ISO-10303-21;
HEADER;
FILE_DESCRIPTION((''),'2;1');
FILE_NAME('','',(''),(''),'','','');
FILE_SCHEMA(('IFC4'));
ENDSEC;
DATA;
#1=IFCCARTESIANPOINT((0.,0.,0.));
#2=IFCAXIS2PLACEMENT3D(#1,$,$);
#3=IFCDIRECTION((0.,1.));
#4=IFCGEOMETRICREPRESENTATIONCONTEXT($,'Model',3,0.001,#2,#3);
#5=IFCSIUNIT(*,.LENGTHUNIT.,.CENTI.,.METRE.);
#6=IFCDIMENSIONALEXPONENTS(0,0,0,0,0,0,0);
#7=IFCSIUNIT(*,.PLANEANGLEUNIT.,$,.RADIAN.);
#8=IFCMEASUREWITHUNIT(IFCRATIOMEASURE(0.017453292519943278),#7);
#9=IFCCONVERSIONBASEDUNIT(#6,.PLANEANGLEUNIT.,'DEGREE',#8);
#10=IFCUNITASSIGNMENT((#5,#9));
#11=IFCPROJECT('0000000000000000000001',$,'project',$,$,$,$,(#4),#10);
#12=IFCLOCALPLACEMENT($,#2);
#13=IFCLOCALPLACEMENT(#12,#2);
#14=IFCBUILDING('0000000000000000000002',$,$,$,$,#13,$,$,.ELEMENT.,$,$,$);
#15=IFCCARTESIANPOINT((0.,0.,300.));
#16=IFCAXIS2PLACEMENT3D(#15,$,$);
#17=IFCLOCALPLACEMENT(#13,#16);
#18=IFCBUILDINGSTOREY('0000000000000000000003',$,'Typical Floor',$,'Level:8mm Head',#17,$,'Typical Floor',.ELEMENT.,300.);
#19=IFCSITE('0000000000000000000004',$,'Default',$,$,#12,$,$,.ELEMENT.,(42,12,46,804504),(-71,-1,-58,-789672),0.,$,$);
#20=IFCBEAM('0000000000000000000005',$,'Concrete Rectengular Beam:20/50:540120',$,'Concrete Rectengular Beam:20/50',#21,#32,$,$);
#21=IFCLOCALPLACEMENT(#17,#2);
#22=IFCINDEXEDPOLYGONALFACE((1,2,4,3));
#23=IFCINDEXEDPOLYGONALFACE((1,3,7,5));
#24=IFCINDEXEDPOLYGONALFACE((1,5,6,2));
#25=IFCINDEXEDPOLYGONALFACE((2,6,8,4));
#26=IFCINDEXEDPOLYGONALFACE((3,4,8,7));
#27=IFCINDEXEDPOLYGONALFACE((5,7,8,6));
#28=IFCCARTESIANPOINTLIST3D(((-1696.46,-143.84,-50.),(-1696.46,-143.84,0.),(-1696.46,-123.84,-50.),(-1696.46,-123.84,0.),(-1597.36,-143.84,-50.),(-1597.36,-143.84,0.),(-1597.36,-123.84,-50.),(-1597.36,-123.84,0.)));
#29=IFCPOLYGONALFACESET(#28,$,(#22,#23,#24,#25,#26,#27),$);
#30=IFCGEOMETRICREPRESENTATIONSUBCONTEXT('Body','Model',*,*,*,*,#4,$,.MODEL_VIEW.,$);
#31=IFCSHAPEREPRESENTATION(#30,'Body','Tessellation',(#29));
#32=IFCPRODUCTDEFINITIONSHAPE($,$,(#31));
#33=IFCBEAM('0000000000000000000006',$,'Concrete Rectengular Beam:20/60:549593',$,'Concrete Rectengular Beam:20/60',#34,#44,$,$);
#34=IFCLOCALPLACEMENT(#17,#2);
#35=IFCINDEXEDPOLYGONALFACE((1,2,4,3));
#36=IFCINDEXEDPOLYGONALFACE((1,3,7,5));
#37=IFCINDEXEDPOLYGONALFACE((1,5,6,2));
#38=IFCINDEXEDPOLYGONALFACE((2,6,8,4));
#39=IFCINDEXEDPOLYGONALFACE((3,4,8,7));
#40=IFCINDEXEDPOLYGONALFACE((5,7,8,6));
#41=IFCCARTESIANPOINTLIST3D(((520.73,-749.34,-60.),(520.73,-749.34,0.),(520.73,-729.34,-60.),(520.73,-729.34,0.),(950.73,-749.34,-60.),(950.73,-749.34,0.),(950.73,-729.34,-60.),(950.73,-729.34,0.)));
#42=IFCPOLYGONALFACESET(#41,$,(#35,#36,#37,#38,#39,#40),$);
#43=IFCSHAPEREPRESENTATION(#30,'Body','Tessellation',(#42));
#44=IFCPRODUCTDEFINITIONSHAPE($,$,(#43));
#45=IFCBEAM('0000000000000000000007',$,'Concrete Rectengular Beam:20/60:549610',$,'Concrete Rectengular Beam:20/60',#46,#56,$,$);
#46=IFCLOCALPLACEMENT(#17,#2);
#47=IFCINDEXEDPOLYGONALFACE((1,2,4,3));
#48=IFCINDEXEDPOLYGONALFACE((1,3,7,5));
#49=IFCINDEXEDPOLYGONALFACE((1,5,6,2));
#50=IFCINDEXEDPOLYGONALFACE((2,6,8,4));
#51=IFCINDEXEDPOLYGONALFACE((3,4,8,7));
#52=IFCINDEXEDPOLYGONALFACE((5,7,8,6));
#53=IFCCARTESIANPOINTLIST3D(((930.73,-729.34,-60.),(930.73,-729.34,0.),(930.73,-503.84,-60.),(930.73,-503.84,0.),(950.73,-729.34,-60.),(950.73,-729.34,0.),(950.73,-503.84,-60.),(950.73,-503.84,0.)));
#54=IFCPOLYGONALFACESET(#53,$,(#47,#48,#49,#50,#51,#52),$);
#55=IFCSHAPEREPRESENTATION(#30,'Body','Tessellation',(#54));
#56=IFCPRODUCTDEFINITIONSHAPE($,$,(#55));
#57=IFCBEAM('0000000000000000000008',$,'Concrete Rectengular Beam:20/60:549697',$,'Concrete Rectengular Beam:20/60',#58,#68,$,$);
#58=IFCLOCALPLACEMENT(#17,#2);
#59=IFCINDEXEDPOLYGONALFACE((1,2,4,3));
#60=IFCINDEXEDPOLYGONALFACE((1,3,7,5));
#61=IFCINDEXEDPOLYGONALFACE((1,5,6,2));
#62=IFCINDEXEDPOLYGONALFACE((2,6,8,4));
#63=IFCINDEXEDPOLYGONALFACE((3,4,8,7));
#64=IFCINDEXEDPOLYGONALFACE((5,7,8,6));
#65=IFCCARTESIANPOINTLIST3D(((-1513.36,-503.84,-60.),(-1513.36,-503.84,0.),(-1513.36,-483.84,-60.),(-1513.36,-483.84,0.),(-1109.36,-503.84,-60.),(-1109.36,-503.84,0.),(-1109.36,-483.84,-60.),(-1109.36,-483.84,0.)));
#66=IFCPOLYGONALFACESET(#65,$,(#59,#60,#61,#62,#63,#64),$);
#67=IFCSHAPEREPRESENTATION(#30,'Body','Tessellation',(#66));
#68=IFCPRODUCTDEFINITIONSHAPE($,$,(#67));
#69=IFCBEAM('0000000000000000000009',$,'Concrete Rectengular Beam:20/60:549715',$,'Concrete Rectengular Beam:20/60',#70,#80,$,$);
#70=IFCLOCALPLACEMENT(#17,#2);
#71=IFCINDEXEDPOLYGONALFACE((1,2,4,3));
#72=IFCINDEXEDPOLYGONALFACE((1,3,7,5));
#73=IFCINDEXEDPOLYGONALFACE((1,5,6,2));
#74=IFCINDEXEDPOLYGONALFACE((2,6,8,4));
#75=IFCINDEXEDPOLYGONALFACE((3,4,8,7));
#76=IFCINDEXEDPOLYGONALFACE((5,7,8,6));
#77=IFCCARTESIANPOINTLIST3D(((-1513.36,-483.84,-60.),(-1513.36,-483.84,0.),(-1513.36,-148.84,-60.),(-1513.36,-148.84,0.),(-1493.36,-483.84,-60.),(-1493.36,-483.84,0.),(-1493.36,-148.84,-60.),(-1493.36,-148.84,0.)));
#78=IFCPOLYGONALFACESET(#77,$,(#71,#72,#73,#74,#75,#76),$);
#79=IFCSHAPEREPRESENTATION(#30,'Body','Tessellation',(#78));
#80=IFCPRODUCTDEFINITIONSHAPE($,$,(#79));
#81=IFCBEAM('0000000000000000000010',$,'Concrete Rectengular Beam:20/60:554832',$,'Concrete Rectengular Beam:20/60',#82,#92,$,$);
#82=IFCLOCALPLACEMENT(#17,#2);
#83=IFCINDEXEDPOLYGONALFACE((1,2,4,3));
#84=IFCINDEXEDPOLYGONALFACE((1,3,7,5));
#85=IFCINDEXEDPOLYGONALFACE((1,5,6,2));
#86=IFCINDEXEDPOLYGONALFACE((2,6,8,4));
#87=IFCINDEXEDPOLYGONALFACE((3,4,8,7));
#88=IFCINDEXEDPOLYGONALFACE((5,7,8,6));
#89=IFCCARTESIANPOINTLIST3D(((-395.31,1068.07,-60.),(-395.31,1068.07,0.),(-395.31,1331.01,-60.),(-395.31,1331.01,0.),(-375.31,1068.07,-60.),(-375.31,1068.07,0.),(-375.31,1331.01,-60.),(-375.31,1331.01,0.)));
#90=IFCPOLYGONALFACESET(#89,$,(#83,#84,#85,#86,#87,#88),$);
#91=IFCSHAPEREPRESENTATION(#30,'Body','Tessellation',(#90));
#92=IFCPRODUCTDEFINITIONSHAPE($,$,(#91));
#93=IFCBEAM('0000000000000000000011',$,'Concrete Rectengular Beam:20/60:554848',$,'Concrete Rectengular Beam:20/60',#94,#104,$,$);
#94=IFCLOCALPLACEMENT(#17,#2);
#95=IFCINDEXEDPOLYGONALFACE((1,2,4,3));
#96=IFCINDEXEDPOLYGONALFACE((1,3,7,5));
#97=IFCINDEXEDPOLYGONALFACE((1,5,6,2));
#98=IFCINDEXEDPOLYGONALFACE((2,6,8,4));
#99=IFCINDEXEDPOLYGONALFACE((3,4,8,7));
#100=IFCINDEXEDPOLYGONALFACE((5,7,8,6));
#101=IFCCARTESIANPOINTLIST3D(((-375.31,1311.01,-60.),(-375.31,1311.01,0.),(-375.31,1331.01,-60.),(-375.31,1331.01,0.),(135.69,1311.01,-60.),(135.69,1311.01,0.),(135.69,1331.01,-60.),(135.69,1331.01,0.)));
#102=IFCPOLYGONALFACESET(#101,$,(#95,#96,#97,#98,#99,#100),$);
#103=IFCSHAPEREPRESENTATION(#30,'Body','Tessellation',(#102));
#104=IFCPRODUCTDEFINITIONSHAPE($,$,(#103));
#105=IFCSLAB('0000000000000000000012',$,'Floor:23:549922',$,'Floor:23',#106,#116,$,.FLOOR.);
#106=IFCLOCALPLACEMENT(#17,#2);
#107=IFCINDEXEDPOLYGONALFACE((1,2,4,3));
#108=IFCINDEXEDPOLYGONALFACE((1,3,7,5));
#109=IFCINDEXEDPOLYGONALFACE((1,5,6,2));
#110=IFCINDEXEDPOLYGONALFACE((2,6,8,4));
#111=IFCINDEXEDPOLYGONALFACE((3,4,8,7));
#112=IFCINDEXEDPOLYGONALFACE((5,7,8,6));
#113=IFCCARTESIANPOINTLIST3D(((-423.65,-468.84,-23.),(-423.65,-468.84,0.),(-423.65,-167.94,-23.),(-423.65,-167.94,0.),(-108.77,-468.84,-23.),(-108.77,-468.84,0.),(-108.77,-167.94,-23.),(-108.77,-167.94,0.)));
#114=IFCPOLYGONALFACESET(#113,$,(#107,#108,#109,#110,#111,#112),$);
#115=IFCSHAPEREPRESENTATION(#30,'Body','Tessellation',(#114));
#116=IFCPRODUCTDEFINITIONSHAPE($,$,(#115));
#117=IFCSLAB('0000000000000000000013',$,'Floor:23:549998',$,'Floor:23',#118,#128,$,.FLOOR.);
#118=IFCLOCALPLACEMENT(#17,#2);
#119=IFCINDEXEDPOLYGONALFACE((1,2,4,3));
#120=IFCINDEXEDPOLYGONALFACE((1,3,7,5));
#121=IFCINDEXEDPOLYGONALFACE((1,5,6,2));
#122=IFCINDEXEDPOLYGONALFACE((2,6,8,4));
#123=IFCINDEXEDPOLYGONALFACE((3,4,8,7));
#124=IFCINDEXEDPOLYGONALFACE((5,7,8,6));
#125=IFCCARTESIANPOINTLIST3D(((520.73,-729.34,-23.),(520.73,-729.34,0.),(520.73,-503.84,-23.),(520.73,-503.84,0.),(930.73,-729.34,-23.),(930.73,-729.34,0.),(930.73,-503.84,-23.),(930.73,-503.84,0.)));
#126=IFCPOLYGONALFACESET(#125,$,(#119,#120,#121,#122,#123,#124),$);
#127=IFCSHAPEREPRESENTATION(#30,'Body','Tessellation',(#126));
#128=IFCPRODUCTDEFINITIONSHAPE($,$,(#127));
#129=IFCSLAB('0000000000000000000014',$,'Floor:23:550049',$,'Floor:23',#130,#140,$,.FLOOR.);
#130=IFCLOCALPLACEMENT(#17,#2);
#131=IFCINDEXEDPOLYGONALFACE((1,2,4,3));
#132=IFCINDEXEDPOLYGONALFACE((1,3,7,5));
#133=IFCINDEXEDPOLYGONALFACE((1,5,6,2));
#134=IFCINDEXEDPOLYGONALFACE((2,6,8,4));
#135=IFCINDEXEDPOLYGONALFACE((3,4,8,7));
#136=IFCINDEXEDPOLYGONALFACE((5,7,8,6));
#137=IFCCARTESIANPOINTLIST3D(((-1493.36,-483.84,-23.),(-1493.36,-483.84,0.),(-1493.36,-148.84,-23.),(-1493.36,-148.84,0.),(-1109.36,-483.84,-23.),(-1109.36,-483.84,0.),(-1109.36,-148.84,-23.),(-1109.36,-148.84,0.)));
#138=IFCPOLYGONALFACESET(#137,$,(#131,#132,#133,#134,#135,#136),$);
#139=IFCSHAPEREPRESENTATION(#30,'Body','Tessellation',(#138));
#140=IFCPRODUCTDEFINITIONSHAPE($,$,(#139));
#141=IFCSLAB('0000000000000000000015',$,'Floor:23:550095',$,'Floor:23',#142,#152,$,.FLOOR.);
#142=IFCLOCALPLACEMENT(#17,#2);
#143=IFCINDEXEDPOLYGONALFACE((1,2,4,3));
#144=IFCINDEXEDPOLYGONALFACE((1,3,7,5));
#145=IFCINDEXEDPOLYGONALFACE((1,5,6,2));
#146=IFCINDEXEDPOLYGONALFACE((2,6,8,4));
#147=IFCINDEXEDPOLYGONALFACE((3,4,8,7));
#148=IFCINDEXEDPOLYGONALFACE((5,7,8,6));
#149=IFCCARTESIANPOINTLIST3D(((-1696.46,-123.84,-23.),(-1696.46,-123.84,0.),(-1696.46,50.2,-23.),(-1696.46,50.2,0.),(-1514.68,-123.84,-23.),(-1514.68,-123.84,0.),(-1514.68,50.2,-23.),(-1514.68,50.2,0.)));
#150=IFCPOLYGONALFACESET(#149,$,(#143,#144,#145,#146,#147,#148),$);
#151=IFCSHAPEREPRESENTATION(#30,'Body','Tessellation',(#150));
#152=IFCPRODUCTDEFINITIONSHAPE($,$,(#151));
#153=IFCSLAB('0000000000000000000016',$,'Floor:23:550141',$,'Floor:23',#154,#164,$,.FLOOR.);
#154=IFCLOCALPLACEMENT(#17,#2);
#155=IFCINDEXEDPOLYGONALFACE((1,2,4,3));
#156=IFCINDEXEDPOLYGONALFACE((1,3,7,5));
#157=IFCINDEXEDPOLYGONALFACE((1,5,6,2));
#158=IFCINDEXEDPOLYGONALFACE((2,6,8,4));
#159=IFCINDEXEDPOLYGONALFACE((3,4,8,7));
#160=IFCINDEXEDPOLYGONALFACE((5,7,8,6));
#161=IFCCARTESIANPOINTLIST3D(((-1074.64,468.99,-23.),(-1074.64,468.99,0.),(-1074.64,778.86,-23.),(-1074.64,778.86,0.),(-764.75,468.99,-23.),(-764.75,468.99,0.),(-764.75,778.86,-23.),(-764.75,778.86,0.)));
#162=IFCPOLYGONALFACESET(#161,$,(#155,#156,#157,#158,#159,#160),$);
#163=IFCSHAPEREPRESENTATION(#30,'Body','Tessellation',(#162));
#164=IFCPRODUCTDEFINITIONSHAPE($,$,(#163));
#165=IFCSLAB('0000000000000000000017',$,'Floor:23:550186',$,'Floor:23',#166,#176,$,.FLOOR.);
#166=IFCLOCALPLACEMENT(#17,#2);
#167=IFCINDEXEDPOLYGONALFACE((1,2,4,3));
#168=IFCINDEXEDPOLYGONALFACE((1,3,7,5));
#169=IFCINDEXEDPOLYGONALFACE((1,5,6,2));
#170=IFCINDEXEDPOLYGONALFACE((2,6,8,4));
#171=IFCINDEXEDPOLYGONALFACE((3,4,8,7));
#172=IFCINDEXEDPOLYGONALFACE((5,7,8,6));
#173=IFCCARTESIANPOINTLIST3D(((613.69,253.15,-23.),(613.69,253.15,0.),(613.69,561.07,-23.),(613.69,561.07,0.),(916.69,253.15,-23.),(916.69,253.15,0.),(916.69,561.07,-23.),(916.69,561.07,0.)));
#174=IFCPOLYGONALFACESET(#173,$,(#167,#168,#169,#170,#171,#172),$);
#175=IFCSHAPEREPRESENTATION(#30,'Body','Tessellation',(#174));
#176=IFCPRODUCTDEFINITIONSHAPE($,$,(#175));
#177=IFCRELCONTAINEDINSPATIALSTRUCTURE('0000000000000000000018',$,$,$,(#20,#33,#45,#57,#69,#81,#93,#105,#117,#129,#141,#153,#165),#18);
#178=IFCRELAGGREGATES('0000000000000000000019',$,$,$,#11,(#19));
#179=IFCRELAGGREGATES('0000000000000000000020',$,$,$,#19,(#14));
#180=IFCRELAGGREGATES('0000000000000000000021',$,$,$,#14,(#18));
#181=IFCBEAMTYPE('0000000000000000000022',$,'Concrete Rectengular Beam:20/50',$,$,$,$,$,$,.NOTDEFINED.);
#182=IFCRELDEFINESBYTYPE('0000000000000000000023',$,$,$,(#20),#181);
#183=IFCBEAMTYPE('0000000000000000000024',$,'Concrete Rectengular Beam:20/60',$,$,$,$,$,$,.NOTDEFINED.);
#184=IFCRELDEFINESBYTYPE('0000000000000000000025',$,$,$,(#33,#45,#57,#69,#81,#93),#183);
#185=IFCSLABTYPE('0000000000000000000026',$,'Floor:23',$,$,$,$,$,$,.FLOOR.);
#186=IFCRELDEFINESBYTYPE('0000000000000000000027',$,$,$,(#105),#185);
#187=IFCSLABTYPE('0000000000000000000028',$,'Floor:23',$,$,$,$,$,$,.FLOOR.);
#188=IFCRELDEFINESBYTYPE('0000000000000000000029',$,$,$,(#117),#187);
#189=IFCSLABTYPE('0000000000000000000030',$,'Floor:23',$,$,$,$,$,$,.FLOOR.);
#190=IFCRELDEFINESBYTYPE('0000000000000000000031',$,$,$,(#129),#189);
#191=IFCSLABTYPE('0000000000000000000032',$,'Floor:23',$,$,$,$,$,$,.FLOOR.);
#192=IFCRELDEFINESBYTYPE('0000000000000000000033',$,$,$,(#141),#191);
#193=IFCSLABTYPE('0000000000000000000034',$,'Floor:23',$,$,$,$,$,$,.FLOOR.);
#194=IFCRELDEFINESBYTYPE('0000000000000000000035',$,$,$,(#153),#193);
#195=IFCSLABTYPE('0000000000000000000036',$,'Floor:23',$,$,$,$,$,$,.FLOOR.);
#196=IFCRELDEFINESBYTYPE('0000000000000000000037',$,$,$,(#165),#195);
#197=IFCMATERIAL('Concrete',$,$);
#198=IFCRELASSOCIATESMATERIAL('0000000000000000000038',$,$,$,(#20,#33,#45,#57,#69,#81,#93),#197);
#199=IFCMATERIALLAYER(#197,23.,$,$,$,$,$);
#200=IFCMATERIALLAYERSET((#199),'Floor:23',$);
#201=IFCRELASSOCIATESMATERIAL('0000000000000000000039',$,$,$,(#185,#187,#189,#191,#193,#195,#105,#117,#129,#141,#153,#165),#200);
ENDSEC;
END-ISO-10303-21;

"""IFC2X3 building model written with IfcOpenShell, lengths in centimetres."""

from ifc_helpers import new_model, entity, si_unit, converted_unit, direction, frame, frame_2d, origin, origin_2d_with_axis, place, context, subcontext, project, spatial, rectangle, extrude, material, layer, layer_set, layer_usage, type_object, element, save


model = new_model("IFC2X3")

# Units and contexts
model_context = context("Model", 3, precision=0.001, world=origin(), true_north=direction((0.0, 1.0)))
body_context = subcontext(model_context, "Body", "Model", "MODEL_VIEW")
ifc_project = project(units=[si_unit("LENGTHUNIT", "METRE", prefix="CENTI"), converted_unit("PLANEANGLEUNIT", "DEGREE", entity("IfcRatioMeasure", 0.017453292519943278), si_unit("PLANEANGLEUNIT", "RADIAN"), dimensions=[0, 0, 0, 0, 0, 0, 0])], contexts=[model_context])

# Site, building, storey
site_placement = place(None, origin())
site = spatial("IfcSite", under=ifc_project, at=site_placement, Name="Default", CompositionType="ELEMENT", RefLatitude=(42, 12, 46, 804504), RefLongitude=(-71, -1, -58, -789672), RefElevation=0.0)
building_placement = place(site_placement, origin())
building = spatial("IfcBuilding", under=site, at=building_placement, CompositionType="ELEMENT")
storey_placement = place(building_placement, frame((0.0, 0.0, 300.0)))
storey = spatial("IfcBuildingStorey", under=building, at=storey_placement, Name="Typical Floor", ObjectType="Level:8mm Head", LongName="Typical Floor", CompositionType="ELEMENT", Elevation=300.0)

# Beams
ifc_material = material(Name="Concrete")
beam_type_1 = type_object("IfcBeamType", Name="Concrete Rectengular Beam:20/50", PredefinedType="NOTDEFINED")
beam_1_placement = place(storey_placement, frame((-1706.46, -133.84, 0.0)))
element("IfcBeam", 1, at=beam_1_placement, inside=storey, type_object=beam_type_1, material=ifc_material, Name="Concrete Rectengular Beam:20/50:540120", ObjectType="Concrete Rectengular Beam:20/50", context=body_context, shape_type="SweptSolid", body=[
    extrude(rectangle(XDim=50.0, YDim=20.0, at=frame_2d((0.0, 0.0), x_axis=(1.0, 0.0))), frame((10.0, 0.0, -25.0), z_axis=(1.0, 0.0, 0.0), x_axis=(0.0, 0.0, -1.0)), (0.0, 0.0, 1.0), 99.11),
])
beam_type_2 = type_object("IfcBeamType", Name="Concrete Rectengular Beam:20/60", PredefinedType="NOTDEFINED")
beam_2_placement = place(storey_placement, frame((510.73, -739.34, 0.0)))
element("IfcBeam", 2, at=beam_2_placement, inside=storey, type_object=beam_type_2, material=ifc_material, Name="Concrete Rectengular Beam:20/60:549593", ObjectType="Concrete Rectengular Beam:20/60", context=body_context, shape_type="SweptSolid", body=[
    extrude(rectangle(XDim=60.0, YDim=20.0, at=frame_2d((0.0, 0.0), x_axis=(1.0, 0.0))), frame((10.0, 0.0, -30.0), z_axis=(1.0, 0.0, 0.0), x_axis=(0.0, 0.0, -1.0)), (0.0, 0.0, 1.0), 430.0),
])
beam_3_placement = place(storey_placement, frame((940.73, -739.34, 0.0), z_axis=(0.0, 0.0, 1.0), x_axis=(0.0, 1.0, 0.0)))
element("IfcBeam", 3, at=beam_3_placement, inside=storey, type_object=beam_type_2, material=ifc_material, Name="Concrete Rectengular Beam:20/60:549610", ObjectType="Concrete Rectengular Beam:20/60", context=body_context, shape_type="SweptSolid", body=[
    extrude(rectangle(XDim=60.0, YDim=20.0, at=frame_2d((0.0, 0.0), x_axis=(1.0, 0.0))), frame((10.0, 0.0, -30.0), z_axis=(1.0, 0.0, 0.0), x_axis=(0.0, 0.0, -1.0)), (0.0, 0.0, 1.0), 225.5),
])
beam_4_placement = place(storey_placement, frame((-1099.36, -493.84, 0.0), z_axis=(0.0, 0.0, 1.0), x_axis=(-1.0, 0.0, 0.0)))
element("IfcBeam", 4, at=beam_4_placement, inside=storey, type_object=beam_type_2, material=ifc_material, Name="Concrete Rectengular Beam:20/60:549697", ObjectType="Concrete Rectengular Beam:20/60", context=body_context, shape_type="SweptSolid", body=[
    extrude(rectangle(XDim=60.0, YDim=20.0, at=frame_2d((0.0, 0.0), x_axis=(1.0, 0.0))), frame((10.0, 0.0, -30.0), z_axis=(1.0, 0.0, 0.0), x_axis=(0.0, 0.0, -1.0)), (0.0, 0.0, 1.0), 404.0),
])
beam_5_placement = place(storey_placement, frame((-1503.36, -493.84, 0.0), z_axis=(0.0, 0.0, 1.0), x_axis=(0.0, 1.0, 0.0)))
element("IfcBeam", 5, at=beam_5_placement, inside=storey, type_object=beam_type_2, material=ifc_material, Name="Concrete Rectengular Beam:20/60:549715", ObjectType="Concrete Rectengular Beam:20/60", context=body_context, shape_type="SweptSolid", body=[
    extrude(rectangle(XDim=60.0, YDim=20.0, at=frame_2d((0.0, 0.0), x_axis=(1.0, 0.0))), frame((10.0, 0.0, -30.0), z_axis=(1.0, 0.0, 0.0), x_axis=(0.0, 0.0, -1.0)), (0.0, 0.0, 1.0), 335.0),
])
beam_6_placement = place(storey_placement, frame((-385.31, 1058.07, 0.0), z_axis=(0.0, 0.0, 1.0), x_axis=(0.0, 1.0, 0.0)))
element("IfcBeam", 6, at=beam_6_placement, inside=storey, type_object=beam_type_2, material=ifc_material, Name="Concrete Rectengular Beam:20/60:554832", ObjectType="Concrete Rectengular Beam:20/60", context=body_context, shape_type="SweptSolid", body=[
    extrude(rectangle(XDim=60.0, YDim=20.0, at=origin_2d_with_axis()), frame((10.0, 0.0, -30.0), z_axis=(1.0, 0.0, 0.0), x_axis=(0.0, 0.0, -1.0)), (0.0, 0.0, 1.0), 262.94),
])
beam_7_placement = place(storey_placement, frame((-385.31, 1321.01, 0.0)))
element("IfcBeam", 7, at=beam_7_placement, inside=storey, type_object=beam_type_2, material=ifc_material, Name="Concrete Rectengular Beam:20/60:554848", ObjectType="Concrete Rectengular Beam:20/60", context=body_context, shape_type="SweptSolid", body=[
    extrude(rectangle(XDim=60.0, YDim=20.0, at=frame_2d((0.0, 0.0), x_axis=(1.0, 0.0))), frame((10.0, 0.0, -30.0), z_axis=(1.0, 0.0, 0.0), x_axis=(0.0, 0.0, -1.0)), (0.0, 0.0, 1.0), 511.0),
])

# Slabs
ifc_layer = layer(ifc_material, 23.0)
ifc_layer_set = layer_set([ifc_layer], Name="Floor:23")
ifc_layer_usage_1 = layer_usage(ifc_layer_set, "AXIS3", "POSITIVE", 0.0)
slab_type_1 = type_object("IfcSlabType", Name="Floor:23", PredefinedType="FLOOR", material=ifc_layer_set)
slab_1_placement = place(storey_placement, origin())
element("IfcSlab", 8, at=slab_1_placement, inside=storey, type_object=slab_type_1, material=ifc_layer_usage_1, Name="Floor:23:549922", ObjectType="Floor:23", PredefinedType="FLOOR", context=body_context, shape_type="SweptSolid", body=[
    extrude(rectangle(XDim=300.91, YDim=314.88, at=frame_2d((0.0, 0.0), x_axis=(1.0, 0.0))), frame((-266.21, -318.39, 0.0), z_axis=(0.0, 0.0, -1.0), x_axis=(0.0, 1.0, 0.0)), (0.0, 0.0, 1.0), 23.0),
])
ifc_layer_usage_2 = layer_usage(ifc_layer_set, "AXIS3", "POSITIVE", 0.0)
slab_type_2 = type_object("IfcSlabType", Name="Floor:23", PredefinedType="FLOOR", material=ifc_layer_set)
slab_2_placement = place(storey_placement, origin())
element("IfcSlab", 9, at=slab_2_placement, inside=storey, type_object=slab_type_2, material=ifc_layer_usage_2, Name="Floor:23:549998", ObjectType="Floor:23", PredefinedType="FLOOR", context=body_context, shape_type="SweptSolid", body=[
    extrude(rectangle(XDim=225.5, YDim=410.0, at=frame_2d((0.0, 0.0), x_axis=(1.0, 0.0))), frame((725.73, -616.59, 0.0), z_axis=(0.0, 0.0, -1.0), x_axis=(0.0, 1.0, 0.0)), (0.0, 0.0, 1.0), 23.0),
])
ifc_layer_usage_3 = layer_usage(ifc_layer_set, "AXIS3", "POSITIVE", 0.0)
slab_type_3 = type_object("IfcSlabType", Name="Floor:23", PredefinedType="FLOOR", material=ifc_layer_set)
slab_3_placement = place(storey_placement, origin())
element("IfcSlab", 10, at=slab_3_placement, inside=storey, type_object=slab_type_3, material=ifc_layer_usage_3, Name="Floor:23:550049", ObjectType="Floor:23", PredefinedType="FLOOR", context=body_context, shape_type="SweptSolid", body=[
    extrude(rectangle(XDim=335.0, YDim=384.0, at=frame_2d((0.0, 0.0), x_axis=(1.0, 0.0))), frame((-1301.36, -316.34, 0.0), z_axis=(0.0, 0.0, -1.0), x_axis=(0.0, 1.0, 0.0)), (0.0, 0.0, 1.0), 23.0),
])
ifc_layer_usage_4 = layer_usage(ifc_layer_set, "AXIS3", "POSITIVE", 0.0)
slab_type_4 = type_object("IfcSlabType", Name="Floor:23", PredefinedType="FLOOR", material=ifc_layer_set)
slab_4_placement = place(storey_placement, origin())
element("IfcSlab", 11, at=slab_4_placement, inside=storey, type_object=slab_type_4, material=ifc_layer_usage_4, Name="Floor:23:550095", ObjectType="Floor:23", PredefinedType="FLOOR", context=body_context, shape_type="SweptSolid", body=[
    extrude(rectangle(XDim=174.04, YDim=181.78, at=origin_2d_with_axis()), frame((-1605.57, -36.82, 0.0), z_axis=(0.0, 0.0, -1.0), x_axis=(0.0, 1.0, 0.0)), (0.0, 0.0, 1.0), 23.0),
])
ifc_layer_usage_5 = layer_usage(ifc_layer_set, "AXIS3", "POSITIVE", 0.0)
slab_type_5 = type_object("IfcSlabType", Name="Floor:23", PredefinedType="FLOOR", material=ifc_layer_set)
slab_5_placement = place(storey_placement, origin())
element("IfcSlab", 12, at=slab_5_placement, inside=storey, type_object=slab_type_5, material=ifc_layer_usage_5, Name="Floor:23:550141", ObjectType="Floor:23", PredefinedType="FLOOR", context=body_context, shape_type="SweptSolid", body=[
    extrude(rectangle(XDim=309.87, YDim=309.89, at=frame_2d((0.0, 0.0), x_axis=(1.0, 0.0))), frame((-919.7, 623.92, 0.0), z_axis=(0.0, 0.0, -1.0), x_axis=(0.0, 1.0, 0.0)), (0.0, 0.0, 1.0), 23.0),
])
ifc_layer_usage_6 = layer_usage(ifc_layer_set, "AXIS3", "POSITIVE", 0.0)
slab_type_6 = type_object("IfcSlabType", Name="Floor:23", PredefinedType="FLOOR", material=ifc_layer_set)
slab_6_placement = place(storey_placement, origin())
element("IfcSlab", 13, at=slab_6_placement, inside=storey, type_object=slab_type_6, material=ifc_layer_usage_6, Name="Floor:23:550186", ObjectType="Floor:23", PredefinedType="FLOOR", context=body_context, shape_type="SweptSolid", body=[
    extrude(rectangle(XDim=307.91, YDim=303.0, at=frame_2d((0.0, 0.0), x_axis=(1.0, 0.0))), frame((765.19, 407.11, 0.0), z_axis=(0.0, 0.0, -1.0), x_axis=(0.0, 1.0, 0.0)), (0.0, 0.0, 1.0), 23.0),
])

save(model, "model.ifc")
